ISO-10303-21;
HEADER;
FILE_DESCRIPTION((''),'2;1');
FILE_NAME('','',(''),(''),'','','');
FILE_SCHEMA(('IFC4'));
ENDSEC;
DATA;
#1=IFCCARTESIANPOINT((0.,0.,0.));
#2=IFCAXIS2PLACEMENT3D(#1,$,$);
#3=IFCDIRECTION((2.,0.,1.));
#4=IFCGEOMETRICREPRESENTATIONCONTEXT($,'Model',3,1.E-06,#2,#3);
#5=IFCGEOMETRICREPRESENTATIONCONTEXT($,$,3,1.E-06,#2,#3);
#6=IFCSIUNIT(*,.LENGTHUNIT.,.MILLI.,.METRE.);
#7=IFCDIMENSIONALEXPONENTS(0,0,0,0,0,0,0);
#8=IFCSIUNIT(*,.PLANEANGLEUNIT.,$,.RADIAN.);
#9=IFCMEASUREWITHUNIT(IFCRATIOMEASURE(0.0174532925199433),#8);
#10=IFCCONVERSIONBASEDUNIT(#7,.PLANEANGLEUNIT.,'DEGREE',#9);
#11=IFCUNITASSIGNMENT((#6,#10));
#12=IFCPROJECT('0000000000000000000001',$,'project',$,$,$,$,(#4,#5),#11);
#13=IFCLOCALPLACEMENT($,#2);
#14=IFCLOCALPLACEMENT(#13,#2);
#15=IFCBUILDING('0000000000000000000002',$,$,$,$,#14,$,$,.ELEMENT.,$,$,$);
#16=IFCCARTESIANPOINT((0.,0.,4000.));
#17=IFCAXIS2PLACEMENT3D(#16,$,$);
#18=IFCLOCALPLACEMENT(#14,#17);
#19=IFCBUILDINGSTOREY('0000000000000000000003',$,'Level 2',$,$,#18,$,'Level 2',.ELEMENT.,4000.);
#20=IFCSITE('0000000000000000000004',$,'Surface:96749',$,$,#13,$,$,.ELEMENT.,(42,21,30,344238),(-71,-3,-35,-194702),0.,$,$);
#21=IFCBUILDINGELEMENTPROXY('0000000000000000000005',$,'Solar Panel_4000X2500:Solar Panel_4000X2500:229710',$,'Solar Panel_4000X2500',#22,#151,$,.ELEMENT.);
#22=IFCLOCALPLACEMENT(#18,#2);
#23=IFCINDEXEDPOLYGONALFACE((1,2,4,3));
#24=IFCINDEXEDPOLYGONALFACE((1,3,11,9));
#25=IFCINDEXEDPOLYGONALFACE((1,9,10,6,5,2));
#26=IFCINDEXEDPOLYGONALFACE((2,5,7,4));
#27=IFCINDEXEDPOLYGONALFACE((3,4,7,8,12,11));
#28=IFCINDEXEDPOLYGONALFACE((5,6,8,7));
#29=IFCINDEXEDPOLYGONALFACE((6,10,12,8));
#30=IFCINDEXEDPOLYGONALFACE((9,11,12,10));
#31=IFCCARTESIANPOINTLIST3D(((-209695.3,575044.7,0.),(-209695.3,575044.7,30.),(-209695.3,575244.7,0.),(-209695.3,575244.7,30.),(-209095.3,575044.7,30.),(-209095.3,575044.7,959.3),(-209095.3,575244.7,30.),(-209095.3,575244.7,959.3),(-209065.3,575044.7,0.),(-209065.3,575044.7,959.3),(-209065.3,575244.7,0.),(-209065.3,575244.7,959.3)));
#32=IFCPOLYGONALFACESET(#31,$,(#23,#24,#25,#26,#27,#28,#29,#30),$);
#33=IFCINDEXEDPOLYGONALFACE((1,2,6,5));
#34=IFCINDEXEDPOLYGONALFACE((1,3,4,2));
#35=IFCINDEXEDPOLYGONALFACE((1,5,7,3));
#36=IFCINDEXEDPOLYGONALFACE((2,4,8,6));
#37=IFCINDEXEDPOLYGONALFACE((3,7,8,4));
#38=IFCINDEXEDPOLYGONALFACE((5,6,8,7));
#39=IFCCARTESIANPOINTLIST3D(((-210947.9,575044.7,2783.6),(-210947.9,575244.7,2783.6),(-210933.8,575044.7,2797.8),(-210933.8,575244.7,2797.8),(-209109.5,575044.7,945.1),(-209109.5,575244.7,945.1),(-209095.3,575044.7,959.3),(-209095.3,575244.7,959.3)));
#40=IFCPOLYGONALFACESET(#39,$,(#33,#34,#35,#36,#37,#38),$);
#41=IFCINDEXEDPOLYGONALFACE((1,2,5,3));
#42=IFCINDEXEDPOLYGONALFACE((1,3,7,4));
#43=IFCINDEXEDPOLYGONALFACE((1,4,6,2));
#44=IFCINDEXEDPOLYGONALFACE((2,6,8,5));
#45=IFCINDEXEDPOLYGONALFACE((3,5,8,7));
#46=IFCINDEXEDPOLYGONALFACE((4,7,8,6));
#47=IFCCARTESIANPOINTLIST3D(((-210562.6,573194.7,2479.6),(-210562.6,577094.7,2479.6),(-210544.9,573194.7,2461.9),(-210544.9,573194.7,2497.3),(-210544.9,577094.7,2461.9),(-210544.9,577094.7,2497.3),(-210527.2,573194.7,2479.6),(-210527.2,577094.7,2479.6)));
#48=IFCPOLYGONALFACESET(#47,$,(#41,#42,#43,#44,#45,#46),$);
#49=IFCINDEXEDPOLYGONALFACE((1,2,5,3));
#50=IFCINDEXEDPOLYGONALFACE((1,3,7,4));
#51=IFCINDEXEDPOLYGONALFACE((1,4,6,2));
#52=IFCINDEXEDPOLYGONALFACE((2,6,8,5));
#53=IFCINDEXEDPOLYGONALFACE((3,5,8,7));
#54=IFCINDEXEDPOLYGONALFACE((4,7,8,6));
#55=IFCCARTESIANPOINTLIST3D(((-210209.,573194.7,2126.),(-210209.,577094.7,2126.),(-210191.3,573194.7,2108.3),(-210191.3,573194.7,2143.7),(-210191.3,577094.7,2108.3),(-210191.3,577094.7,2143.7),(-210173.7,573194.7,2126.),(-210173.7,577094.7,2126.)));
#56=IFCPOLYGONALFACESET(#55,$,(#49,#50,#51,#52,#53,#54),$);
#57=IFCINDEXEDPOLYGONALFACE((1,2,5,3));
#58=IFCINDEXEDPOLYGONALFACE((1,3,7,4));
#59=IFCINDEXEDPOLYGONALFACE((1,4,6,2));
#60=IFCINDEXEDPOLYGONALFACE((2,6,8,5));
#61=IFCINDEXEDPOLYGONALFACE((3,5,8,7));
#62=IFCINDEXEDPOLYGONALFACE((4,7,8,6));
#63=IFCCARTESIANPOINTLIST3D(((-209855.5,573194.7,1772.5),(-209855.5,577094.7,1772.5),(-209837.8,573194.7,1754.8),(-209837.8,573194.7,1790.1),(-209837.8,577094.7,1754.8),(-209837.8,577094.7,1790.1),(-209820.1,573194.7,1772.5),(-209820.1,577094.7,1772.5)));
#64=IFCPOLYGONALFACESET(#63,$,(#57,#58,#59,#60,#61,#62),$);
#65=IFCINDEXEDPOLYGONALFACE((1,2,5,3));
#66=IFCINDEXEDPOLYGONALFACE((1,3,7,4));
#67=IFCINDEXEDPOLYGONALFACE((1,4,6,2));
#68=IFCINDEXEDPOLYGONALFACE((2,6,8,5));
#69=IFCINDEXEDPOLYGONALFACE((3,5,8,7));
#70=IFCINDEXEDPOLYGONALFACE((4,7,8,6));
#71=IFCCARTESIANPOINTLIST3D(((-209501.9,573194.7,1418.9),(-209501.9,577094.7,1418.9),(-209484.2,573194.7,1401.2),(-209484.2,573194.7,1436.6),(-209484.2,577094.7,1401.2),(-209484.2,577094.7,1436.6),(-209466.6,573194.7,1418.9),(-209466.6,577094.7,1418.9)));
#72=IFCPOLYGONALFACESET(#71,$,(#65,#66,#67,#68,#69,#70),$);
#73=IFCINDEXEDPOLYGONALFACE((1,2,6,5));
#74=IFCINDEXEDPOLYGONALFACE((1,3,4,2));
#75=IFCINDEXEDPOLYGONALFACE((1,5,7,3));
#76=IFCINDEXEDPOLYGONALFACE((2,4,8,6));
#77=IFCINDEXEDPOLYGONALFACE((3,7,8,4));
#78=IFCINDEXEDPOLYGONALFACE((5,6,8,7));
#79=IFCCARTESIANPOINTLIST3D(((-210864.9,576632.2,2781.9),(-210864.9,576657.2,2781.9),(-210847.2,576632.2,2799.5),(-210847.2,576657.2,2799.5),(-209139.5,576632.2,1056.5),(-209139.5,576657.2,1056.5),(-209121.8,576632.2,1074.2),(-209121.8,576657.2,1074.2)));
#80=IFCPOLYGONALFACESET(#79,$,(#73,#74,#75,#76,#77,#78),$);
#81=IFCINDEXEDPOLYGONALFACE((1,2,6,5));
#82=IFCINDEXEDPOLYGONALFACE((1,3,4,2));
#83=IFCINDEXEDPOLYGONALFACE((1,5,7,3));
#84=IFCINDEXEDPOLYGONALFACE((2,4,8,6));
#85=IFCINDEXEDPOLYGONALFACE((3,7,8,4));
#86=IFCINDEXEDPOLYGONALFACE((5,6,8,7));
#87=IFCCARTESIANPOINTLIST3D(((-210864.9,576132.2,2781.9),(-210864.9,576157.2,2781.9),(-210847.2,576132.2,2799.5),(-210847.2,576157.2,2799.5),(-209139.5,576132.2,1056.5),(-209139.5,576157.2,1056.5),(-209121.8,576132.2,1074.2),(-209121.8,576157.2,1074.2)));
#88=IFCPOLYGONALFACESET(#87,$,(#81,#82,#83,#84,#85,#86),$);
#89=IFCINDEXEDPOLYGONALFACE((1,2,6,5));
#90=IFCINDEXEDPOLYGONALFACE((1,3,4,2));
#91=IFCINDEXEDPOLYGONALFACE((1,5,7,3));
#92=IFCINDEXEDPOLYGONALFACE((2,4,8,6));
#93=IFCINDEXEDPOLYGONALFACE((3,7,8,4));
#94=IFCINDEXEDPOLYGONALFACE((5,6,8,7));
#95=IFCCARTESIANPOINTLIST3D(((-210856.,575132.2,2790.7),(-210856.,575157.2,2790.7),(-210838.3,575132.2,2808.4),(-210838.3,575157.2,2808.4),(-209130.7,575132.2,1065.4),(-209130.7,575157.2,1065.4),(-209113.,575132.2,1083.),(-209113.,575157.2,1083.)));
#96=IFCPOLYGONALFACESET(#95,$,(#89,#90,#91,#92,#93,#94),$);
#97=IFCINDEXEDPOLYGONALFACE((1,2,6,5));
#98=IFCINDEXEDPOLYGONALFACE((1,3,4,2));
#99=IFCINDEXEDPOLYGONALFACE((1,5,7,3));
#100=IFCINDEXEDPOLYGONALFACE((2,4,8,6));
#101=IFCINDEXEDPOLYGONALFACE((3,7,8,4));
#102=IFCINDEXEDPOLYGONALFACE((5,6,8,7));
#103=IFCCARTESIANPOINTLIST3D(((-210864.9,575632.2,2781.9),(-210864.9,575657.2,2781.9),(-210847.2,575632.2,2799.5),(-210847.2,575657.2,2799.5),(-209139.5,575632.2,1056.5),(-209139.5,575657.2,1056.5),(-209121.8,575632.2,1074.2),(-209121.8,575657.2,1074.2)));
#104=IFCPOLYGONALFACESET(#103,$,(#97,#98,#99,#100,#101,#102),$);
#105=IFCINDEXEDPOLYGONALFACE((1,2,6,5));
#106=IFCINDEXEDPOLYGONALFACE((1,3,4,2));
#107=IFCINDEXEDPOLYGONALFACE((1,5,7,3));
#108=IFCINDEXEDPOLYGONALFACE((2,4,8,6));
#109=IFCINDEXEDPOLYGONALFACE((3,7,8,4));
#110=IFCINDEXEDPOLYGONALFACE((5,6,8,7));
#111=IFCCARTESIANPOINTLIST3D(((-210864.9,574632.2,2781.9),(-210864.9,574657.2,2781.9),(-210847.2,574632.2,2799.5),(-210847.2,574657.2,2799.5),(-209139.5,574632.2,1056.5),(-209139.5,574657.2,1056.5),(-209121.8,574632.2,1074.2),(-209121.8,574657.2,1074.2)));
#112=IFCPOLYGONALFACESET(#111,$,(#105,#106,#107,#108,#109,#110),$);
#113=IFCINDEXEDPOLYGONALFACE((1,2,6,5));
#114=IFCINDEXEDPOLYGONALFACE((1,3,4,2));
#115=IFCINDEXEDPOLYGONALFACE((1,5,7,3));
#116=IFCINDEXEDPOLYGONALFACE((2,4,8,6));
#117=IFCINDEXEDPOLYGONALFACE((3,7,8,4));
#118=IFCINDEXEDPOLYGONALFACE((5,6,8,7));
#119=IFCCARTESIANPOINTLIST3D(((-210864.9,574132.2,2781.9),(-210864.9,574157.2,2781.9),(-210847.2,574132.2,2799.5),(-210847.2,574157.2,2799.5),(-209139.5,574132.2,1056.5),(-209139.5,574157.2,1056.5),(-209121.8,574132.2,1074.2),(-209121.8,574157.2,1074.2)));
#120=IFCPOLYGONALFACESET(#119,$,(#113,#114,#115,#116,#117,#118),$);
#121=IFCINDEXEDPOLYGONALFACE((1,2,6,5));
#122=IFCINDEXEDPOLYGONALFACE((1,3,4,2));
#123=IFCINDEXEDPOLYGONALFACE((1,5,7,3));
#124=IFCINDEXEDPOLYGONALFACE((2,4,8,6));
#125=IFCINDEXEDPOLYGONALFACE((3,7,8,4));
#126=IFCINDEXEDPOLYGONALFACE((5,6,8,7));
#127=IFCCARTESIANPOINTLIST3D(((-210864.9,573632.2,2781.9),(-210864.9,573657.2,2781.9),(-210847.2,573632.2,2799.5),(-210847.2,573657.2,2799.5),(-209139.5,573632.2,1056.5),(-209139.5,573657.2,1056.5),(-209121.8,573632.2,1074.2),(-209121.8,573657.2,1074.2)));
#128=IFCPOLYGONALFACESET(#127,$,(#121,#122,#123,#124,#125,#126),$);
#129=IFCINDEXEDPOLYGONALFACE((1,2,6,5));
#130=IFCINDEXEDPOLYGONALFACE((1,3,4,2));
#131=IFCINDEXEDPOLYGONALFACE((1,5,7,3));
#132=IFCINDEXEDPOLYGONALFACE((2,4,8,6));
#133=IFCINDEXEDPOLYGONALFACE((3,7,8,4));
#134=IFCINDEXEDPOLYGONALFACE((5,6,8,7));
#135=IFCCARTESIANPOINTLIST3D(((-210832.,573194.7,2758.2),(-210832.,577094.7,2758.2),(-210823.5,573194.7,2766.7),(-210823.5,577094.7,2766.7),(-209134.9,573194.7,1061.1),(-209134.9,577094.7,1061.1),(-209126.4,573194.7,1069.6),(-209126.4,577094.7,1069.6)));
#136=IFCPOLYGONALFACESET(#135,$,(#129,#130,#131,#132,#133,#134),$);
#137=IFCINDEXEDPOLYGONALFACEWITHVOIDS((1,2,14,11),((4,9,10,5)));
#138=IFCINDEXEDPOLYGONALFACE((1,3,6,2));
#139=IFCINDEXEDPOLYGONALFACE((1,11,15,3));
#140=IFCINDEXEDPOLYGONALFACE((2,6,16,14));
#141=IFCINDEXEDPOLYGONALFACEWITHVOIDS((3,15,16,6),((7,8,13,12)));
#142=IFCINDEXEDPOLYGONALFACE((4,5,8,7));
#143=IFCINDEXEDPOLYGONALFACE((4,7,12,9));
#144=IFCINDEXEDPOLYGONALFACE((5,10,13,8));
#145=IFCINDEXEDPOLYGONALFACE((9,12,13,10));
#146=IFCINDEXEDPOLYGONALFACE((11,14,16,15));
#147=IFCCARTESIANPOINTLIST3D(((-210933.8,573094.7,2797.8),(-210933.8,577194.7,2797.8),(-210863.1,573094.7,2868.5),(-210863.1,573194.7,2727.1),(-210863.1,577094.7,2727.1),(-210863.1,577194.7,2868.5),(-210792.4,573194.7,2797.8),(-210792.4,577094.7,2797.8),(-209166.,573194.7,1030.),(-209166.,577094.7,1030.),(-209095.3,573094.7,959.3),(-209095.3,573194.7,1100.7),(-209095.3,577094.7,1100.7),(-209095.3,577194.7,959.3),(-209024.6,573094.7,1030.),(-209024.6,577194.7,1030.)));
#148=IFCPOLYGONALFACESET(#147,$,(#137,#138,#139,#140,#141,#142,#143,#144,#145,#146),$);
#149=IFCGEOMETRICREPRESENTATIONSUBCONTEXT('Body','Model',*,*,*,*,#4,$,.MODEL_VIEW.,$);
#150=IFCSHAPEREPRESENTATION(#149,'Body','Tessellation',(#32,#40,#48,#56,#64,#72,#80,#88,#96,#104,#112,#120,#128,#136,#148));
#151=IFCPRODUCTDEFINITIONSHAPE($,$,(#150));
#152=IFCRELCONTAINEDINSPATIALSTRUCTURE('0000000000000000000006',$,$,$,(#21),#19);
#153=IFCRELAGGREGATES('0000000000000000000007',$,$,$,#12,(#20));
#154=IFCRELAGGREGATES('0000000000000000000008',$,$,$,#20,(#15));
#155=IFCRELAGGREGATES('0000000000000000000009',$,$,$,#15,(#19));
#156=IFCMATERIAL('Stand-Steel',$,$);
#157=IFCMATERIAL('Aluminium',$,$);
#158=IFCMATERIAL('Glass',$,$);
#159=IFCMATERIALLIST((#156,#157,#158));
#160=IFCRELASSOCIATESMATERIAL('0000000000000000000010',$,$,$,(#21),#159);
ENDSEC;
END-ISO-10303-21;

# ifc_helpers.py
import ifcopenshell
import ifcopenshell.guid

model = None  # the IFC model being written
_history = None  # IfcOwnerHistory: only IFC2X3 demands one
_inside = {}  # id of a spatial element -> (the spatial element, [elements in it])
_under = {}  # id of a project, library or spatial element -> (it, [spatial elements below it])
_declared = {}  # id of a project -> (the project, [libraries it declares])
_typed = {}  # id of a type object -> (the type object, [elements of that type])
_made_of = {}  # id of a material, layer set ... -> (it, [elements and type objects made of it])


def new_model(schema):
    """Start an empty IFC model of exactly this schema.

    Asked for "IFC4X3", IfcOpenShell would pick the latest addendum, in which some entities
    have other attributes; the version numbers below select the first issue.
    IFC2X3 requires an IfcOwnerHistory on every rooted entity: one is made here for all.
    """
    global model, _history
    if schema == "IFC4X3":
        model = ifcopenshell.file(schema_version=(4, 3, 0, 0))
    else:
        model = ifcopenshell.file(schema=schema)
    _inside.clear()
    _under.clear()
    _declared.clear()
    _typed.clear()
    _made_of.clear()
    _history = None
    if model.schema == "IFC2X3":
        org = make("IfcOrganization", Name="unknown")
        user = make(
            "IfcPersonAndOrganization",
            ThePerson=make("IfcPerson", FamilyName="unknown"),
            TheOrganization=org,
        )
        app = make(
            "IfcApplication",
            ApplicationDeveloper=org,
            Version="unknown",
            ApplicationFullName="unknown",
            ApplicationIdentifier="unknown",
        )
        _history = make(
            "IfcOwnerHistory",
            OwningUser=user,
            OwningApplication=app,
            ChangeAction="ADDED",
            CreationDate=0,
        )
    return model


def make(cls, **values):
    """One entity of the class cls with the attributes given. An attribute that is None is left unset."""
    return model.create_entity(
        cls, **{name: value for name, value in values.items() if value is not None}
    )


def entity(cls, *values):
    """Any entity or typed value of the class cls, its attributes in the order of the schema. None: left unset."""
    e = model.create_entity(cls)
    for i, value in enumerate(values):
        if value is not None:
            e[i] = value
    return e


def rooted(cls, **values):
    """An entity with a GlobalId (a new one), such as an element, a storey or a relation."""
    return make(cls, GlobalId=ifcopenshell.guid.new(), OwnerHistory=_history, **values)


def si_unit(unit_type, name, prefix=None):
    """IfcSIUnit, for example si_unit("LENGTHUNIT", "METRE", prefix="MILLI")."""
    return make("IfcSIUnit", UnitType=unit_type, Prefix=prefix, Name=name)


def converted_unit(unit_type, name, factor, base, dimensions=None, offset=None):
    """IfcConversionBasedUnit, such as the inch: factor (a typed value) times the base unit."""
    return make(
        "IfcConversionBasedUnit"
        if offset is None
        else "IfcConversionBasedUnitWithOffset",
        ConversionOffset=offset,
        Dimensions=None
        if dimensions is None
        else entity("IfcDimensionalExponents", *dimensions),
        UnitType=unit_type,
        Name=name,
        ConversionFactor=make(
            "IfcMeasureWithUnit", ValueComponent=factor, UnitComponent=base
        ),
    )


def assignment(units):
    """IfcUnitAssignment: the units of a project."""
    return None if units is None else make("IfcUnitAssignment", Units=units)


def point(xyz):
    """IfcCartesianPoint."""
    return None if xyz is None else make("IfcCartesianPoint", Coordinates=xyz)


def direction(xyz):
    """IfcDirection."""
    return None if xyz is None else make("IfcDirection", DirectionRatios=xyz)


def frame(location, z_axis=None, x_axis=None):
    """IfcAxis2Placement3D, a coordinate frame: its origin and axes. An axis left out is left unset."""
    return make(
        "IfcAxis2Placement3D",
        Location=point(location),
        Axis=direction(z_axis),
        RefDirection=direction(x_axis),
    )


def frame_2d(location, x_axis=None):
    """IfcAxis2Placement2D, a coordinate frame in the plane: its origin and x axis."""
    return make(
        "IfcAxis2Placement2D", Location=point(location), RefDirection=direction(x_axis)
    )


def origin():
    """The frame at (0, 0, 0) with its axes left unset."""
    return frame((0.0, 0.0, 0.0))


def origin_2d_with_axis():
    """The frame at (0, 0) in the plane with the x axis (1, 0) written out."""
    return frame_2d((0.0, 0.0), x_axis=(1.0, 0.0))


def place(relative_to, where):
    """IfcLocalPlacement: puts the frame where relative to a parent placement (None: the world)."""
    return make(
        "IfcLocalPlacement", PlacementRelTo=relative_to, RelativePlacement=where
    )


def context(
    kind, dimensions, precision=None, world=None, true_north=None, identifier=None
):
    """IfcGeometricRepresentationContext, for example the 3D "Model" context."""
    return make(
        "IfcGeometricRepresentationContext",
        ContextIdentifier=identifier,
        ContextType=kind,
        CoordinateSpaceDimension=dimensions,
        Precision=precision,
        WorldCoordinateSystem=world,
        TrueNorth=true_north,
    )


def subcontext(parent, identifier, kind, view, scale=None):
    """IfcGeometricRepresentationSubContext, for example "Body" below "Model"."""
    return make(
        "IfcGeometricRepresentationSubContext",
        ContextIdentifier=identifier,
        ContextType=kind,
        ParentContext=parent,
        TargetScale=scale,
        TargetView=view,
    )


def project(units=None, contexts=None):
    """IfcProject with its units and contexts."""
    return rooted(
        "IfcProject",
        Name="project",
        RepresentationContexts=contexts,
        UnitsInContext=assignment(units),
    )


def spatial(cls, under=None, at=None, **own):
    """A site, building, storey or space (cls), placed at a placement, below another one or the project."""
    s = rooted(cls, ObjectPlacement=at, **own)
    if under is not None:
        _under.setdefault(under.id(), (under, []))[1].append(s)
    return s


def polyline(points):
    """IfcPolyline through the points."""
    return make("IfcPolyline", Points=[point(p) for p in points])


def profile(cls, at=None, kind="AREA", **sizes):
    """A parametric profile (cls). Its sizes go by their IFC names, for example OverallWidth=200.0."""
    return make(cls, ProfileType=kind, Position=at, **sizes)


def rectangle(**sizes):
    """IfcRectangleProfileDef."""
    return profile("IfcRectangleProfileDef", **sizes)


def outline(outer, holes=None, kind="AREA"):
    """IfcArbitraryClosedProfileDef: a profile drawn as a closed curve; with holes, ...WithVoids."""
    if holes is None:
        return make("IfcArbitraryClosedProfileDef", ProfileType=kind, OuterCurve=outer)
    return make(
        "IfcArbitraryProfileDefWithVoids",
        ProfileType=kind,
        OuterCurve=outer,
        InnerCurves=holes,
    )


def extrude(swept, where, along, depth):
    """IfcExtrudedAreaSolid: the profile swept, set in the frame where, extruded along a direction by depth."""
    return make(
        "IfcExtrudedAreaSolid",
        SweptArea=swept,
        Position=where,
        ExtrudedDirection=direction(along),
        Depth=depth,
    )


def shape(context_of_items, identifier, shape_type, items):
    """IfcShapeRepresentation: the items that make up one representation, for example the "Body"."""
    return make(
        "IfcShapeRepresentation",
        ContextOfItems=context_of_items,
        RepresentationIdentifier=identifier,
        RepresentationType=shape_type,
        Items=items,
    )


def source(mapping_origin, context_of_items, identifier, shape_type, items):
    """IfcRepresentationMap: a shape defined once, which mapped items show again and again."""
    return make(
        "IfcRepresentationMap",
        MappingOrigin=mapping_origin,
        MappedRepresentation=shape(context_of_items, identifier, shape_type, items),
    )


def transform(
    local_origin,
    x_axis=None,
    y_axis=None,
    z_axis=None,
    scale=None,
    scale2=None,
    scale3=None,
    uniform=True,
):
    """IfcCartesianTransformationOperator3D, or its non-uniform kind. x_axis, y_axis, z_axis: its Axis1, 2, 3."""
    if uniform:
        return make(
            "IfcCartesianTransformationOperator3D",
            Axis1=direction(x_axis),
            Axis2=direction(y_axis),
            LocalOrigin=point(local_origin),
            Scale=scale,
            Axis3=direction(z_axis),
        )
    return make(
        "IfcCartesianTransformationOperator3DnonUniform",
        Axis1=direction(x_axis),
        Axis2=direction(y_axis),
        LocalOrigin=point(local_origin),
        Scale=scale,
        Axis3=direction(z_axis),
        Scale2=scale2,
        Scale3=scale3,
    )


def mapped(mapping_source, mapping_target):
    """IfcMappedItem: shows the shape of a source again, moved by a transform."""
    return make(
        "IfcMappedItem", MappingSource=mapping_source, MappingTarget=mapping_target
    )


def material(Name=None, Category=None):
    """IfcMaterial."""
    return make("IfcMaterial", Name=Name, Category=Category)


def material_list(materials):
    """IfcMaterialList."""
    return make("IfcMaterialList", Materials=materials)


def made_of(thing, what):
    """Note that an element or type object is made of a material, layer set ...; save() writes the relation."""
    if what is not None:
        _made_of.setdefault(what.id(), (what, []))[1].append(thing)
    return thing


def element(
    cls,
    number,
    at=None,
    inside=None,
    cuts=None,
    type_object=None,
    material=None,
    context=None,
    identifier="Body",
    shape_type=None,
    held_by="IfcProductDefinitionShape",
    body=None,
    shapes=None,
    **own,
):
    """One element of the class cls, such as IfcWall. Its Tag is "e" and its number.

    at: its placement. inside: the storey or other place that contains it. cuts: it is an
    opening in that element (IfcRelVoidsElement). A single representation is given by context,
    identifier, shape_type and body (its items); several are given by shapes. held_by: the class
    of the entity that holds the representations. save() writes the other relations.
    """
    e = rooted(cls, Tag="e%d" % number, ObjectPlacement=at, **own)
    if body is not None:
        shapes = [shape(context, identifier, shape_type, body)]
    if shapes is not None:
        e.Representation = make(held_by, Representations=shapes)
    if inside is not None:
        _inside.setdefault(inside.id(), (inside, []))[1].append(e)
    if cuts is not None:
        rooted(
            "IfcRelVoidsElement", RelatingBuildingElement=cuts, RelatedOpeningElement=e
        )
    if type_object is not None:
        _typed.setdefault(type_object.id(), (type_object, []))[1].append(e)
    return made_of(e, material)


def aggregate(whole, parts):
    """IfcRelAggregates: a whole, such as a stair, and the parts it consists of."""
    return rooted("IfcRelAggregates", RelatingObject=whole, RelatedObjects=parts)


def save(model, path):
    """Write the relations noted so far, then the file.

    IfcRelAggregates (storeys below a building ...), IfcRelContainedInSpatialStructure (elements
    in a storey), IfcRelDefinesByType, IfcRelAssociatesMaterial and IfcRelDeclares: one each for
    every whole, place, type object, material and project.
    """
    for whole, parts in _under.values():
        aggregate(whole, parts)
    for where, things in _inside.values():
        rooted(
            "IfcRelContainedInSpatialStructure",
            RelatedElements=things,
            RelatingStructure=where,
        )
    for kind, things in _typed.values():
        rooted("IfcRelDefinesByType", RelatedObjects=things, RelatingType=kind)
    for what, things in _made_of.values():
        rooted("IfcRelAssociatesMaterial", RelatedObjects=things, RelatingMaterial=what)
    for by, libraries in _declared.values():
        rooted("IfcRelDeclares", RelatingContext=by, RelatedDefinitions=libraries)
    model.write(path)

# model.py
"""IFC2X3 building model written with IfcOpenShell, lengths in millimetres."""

from ifc_helpers import new_model, entity, si_unit, converted_unit, direction, frame, frame_2d, origin, origin_2d_with_axis, place, context, subcontext, project, spatial, polyline, rectangle, outline, extrude, source, transform, mapped, material, material_list, element, save


model = new_model("IFC2X3")

# Units and contexts
model_context = context("Model", 3, precision=1e-06, world=origin(), true_north=direction((2.0, 0.0, 1.0)))
context_of_model = context(None, 3, precision=1e-06, world=origin(), true_north=direction((2.0, 0.0, 1.0)))
body_context = subcontext(model_context, "Body", "Model", "MODEL_VIEW")
ifc_project = project(units=[si_unit("LENGTHUNIT", "METRE", prefix="MILLI"), converted_unit("PLANEANGLEUNIT", "DEGREE", entity("IfcRatioMeasure", 0.0174532925199433), si_unit("PLANEANGLEUNIT", "RADIAN"), dimensions=[0, 0, 0, 0, 0, 0, 0])], contexts=[model_context, context_of_model])

# Site, building, storey
site_placement = place(None, origin())
site = spatial("IfcSite", under=ifc_project, at=site_placement, Name="Surface:96749", CompositionType="ELEMENT", RefLatitude=(42, 21, 30, 344238), RefLongitude=(-71, -3, -35, -194702), RefElevation=0.0)
building_placement = place(site_placement, origin())
building = spatial("IfcBuilding", under=site, at=building_placement, CompositionType="ELEMENT")
storey_placement = place(building_placement, frame((0.0, 0.0, 4000.0)))
storey = spatial("IfcBuildingStorey", under=building, at=storey_placement, Name="Level 2", LongName="Level 2", CompositionType="ELEMENT", Elevation=4000.0)

# Building element proxy
ifc_material_1 = material(Name="Stand-Steel")
ifc_material_2 = material(Name="Aluminium")
ifc_material_3 = material(Name="Glass")
shared_shape = source(origin(), body_context, "Body", "SweptSolid", [
    extrude(outline(polyline([(-629.5, -220.0), (329.8, -220.0), (329.8, 410.0), (299.8, 410.0), (299.8, -190.0), (-629.5, -190.0), (-629.5, -220.0)])), frame((-190.0, -100.0, 299.8), z_axis=(0.0, 1.0, 0.0), x_axis=(0.0, 0.0, -1.0)), (0.0, 0.0, 1.0), 200.0),
    extrude(rectangle(XDim=20.0, YDim=200.0, at=frame_2d((0.0, 0.0), x_axis=(0.0, 1.0))), frame((-7.1, 0.0, 922.2), z_axis=(-0.707107, 0.0, 0.707107), x_axis=(0.0, 1.0, 0.0)), (0.0, 0.0, 1.0), 2600.0),
    extrude(rectangle(XDim=25.0, YDim=25.0, at=frame_2d((0.0, 0.0), x_axis=(1.0, 0.0))), frame((-1449.6, -1950.0, 2449.6), z_axis=(0.0, 1.0, 0.0), x_axis=(-0.707107, 0.0, -0.707107)), (0.0, 0.0, 1.0), 3900.0),
    extrude(rectangle(XDim=25.0, YDim=25.0, at=origin_2d_with_axis()), frame((-1096.0, -1950.0, 2096.0), z_axis=(0.0, 1.0, 0.0), x_axis=(-0.707107, 0.0, -0.707107)), (0.0, 0.0, 1.0), 3900.0),
    extrude(rectangle(XDim=25.0, YDim=25.0, at=origin_2d_with_axis()), frame((-742.5, -1950.0, 1742.5), z_axis=(0.0, 1.0, 0.0), x_axis=(-0.707107, 0.0, -0.707107)), (0.0, 0.0, 1.0), 3900.0),
    extrude(rectangle(XDim=25.0, YDim=25.0, at=frame_2d((0.0, 0.0), x_axis=(1.0, 0.0))), frame((-388.9, -1950.0, 1388.9), z_axis=(0.0, 1.0, 0.0), x_axis=(-0.707107, 0.0, -0.707107)), (0.0, 0.0, 1.0), 3900.0),
    extrude(rectangle(XDim=25.0, YDim=25.0, at=frame_2d((0.0, 0.0), x_axis=(0.0, 1.0))), frame((-35.4, 1500.0, 1035.4), z_axis=(-0.707107, 0.0, 0.707107), x_axis=(0.0, 1.0, 0.0)), (0.0, 0.0, 1.0), 2440.0),
    extrude(rectangle(XDim=25.0, YDim=25.0, at=frame_2d((0.0, 0.0), x_axis=(0.0, 1.0))), frame((-35.4, 1000.0, 1035.4), z_axis=(-0.707107, 0.0, 0.707107), x_axis=(0.0, 1.0, 0.0)), (0.0, 0.0, 1.0), 2440.0),
    extrude(rectangle(XDim=25.0, YDim=25.0, at=frame_2d((0.0, 0.0), x_axis=(0.0, 1.0))), frame((-26.5, 0.0, 1044.2), z_axis=(-0.707107, 0.0, 0.707107), x_axis=(0.0, -1.0, 0.0)), (0.0, 0.0, 1.0), 2440.0),
    extrude(rectangle(XDim=25.0, YDim=25.0, at=frame_2d((0.0, 0.0), x_axis=(0.0, 1.0))), frame((-35.4, 500.0, 1035.4), z_axis=(-0.707107, 0.0, 0.707107), x_axis=(0.0, 1.0, 0.0)), (0.0, 0.0, 1.0), 2440.0),
    extrude(rectangle(XDim=25.0, YDim=25.0, at=frame_2d((0.0, 0.0), x_axis=(0.0, 1.0))), frame((-35.4, -500.0, 1035.4), z_axis=(-0.707107, 0.0, 0.707107), x_axis=(0.0, 1.0, 0.0)), (0.0, 0.0, 1.0), 2440.0),
    extrude(rectangle(XDim=25.0, YDim=25.0, at=frame_2d((0.0, 0.0), x_axis=(0.0, 1.0))), frame((-35.4, -1000.0, 1035.4), z_axis=(-0.707107, 0.0, 0.707107), x_axis=(0.0, 1.0, 0.0)), (0.0, 0.0, 1.0), 2440.0),
    extrude(rectangle(XDim=25.0, YDim=25.0, at=frame_2d((0.0, 0.0), x_axis=(0.0, 1.0))), frame((-35.4, -1500.0, 1035.4), z_axis=(-0.707107, 0.0, 0.707107), x_axis=(0.0, 1.0, 0.0)), (0.0, 0.0, 1.0), 2440.0),
    extrude(rectangle(XDim=2400.0, YDim=12.0, at=frame_2d((0.0, 0.0), x_axis=(1.0, 0.0))), frame((-883.9, -1950.0, 1883.9), z_axis=(0.0, 1.0, 0.0), x_axis=(0.707107, 0.0, -0.707107)), (0.0, 0.0, 1.0), 3900.0),
    extrude(outline(polyline([(-2050.0, -1300.0), (2050.0, -1300.0), (2050.0, 1300.0), (-2050.0, 1300.0), (-2050.0, -1300.0)]), holes=[polyline([(1950.0, -1200.0), (-1950.0, -1200.0), (-1950.0, 1200.0), (1950.0, 1200.0), (1950.0, -1200.0)])]), frame((-919.2, 0.0, 1848.5), z_axis=(0.707107, 0.0, 0.707107), x_axis=(0.0, 1.0, 0.0)), (0.0, 0.0, 1.0), 100.0),
])
ifc_material_list_1 = material_list([ifc_material_1, ifc_material_2, ifc_material_3])
proxy_1_placement = place(storey_placement, frame((-209095.3, 575144.7, 30.0)))
element("IfcBuildingElementProxy", 1, at=proxy_1_placement, inside=storey, material=ifc_material_list_1, Name="Solar Panel_4000X2500:Solar Panel_4000X2500:229710", ObjectType="Solar Panel_4000X2500", CompositionType="ELEMENT", context=body_context, shape_type="MappedRepresentation", body=[
    mapped(shared_shape, transform((0.0, 0.0, 0.0), scale=1.0)),
])

save(model, "model.ifc")
